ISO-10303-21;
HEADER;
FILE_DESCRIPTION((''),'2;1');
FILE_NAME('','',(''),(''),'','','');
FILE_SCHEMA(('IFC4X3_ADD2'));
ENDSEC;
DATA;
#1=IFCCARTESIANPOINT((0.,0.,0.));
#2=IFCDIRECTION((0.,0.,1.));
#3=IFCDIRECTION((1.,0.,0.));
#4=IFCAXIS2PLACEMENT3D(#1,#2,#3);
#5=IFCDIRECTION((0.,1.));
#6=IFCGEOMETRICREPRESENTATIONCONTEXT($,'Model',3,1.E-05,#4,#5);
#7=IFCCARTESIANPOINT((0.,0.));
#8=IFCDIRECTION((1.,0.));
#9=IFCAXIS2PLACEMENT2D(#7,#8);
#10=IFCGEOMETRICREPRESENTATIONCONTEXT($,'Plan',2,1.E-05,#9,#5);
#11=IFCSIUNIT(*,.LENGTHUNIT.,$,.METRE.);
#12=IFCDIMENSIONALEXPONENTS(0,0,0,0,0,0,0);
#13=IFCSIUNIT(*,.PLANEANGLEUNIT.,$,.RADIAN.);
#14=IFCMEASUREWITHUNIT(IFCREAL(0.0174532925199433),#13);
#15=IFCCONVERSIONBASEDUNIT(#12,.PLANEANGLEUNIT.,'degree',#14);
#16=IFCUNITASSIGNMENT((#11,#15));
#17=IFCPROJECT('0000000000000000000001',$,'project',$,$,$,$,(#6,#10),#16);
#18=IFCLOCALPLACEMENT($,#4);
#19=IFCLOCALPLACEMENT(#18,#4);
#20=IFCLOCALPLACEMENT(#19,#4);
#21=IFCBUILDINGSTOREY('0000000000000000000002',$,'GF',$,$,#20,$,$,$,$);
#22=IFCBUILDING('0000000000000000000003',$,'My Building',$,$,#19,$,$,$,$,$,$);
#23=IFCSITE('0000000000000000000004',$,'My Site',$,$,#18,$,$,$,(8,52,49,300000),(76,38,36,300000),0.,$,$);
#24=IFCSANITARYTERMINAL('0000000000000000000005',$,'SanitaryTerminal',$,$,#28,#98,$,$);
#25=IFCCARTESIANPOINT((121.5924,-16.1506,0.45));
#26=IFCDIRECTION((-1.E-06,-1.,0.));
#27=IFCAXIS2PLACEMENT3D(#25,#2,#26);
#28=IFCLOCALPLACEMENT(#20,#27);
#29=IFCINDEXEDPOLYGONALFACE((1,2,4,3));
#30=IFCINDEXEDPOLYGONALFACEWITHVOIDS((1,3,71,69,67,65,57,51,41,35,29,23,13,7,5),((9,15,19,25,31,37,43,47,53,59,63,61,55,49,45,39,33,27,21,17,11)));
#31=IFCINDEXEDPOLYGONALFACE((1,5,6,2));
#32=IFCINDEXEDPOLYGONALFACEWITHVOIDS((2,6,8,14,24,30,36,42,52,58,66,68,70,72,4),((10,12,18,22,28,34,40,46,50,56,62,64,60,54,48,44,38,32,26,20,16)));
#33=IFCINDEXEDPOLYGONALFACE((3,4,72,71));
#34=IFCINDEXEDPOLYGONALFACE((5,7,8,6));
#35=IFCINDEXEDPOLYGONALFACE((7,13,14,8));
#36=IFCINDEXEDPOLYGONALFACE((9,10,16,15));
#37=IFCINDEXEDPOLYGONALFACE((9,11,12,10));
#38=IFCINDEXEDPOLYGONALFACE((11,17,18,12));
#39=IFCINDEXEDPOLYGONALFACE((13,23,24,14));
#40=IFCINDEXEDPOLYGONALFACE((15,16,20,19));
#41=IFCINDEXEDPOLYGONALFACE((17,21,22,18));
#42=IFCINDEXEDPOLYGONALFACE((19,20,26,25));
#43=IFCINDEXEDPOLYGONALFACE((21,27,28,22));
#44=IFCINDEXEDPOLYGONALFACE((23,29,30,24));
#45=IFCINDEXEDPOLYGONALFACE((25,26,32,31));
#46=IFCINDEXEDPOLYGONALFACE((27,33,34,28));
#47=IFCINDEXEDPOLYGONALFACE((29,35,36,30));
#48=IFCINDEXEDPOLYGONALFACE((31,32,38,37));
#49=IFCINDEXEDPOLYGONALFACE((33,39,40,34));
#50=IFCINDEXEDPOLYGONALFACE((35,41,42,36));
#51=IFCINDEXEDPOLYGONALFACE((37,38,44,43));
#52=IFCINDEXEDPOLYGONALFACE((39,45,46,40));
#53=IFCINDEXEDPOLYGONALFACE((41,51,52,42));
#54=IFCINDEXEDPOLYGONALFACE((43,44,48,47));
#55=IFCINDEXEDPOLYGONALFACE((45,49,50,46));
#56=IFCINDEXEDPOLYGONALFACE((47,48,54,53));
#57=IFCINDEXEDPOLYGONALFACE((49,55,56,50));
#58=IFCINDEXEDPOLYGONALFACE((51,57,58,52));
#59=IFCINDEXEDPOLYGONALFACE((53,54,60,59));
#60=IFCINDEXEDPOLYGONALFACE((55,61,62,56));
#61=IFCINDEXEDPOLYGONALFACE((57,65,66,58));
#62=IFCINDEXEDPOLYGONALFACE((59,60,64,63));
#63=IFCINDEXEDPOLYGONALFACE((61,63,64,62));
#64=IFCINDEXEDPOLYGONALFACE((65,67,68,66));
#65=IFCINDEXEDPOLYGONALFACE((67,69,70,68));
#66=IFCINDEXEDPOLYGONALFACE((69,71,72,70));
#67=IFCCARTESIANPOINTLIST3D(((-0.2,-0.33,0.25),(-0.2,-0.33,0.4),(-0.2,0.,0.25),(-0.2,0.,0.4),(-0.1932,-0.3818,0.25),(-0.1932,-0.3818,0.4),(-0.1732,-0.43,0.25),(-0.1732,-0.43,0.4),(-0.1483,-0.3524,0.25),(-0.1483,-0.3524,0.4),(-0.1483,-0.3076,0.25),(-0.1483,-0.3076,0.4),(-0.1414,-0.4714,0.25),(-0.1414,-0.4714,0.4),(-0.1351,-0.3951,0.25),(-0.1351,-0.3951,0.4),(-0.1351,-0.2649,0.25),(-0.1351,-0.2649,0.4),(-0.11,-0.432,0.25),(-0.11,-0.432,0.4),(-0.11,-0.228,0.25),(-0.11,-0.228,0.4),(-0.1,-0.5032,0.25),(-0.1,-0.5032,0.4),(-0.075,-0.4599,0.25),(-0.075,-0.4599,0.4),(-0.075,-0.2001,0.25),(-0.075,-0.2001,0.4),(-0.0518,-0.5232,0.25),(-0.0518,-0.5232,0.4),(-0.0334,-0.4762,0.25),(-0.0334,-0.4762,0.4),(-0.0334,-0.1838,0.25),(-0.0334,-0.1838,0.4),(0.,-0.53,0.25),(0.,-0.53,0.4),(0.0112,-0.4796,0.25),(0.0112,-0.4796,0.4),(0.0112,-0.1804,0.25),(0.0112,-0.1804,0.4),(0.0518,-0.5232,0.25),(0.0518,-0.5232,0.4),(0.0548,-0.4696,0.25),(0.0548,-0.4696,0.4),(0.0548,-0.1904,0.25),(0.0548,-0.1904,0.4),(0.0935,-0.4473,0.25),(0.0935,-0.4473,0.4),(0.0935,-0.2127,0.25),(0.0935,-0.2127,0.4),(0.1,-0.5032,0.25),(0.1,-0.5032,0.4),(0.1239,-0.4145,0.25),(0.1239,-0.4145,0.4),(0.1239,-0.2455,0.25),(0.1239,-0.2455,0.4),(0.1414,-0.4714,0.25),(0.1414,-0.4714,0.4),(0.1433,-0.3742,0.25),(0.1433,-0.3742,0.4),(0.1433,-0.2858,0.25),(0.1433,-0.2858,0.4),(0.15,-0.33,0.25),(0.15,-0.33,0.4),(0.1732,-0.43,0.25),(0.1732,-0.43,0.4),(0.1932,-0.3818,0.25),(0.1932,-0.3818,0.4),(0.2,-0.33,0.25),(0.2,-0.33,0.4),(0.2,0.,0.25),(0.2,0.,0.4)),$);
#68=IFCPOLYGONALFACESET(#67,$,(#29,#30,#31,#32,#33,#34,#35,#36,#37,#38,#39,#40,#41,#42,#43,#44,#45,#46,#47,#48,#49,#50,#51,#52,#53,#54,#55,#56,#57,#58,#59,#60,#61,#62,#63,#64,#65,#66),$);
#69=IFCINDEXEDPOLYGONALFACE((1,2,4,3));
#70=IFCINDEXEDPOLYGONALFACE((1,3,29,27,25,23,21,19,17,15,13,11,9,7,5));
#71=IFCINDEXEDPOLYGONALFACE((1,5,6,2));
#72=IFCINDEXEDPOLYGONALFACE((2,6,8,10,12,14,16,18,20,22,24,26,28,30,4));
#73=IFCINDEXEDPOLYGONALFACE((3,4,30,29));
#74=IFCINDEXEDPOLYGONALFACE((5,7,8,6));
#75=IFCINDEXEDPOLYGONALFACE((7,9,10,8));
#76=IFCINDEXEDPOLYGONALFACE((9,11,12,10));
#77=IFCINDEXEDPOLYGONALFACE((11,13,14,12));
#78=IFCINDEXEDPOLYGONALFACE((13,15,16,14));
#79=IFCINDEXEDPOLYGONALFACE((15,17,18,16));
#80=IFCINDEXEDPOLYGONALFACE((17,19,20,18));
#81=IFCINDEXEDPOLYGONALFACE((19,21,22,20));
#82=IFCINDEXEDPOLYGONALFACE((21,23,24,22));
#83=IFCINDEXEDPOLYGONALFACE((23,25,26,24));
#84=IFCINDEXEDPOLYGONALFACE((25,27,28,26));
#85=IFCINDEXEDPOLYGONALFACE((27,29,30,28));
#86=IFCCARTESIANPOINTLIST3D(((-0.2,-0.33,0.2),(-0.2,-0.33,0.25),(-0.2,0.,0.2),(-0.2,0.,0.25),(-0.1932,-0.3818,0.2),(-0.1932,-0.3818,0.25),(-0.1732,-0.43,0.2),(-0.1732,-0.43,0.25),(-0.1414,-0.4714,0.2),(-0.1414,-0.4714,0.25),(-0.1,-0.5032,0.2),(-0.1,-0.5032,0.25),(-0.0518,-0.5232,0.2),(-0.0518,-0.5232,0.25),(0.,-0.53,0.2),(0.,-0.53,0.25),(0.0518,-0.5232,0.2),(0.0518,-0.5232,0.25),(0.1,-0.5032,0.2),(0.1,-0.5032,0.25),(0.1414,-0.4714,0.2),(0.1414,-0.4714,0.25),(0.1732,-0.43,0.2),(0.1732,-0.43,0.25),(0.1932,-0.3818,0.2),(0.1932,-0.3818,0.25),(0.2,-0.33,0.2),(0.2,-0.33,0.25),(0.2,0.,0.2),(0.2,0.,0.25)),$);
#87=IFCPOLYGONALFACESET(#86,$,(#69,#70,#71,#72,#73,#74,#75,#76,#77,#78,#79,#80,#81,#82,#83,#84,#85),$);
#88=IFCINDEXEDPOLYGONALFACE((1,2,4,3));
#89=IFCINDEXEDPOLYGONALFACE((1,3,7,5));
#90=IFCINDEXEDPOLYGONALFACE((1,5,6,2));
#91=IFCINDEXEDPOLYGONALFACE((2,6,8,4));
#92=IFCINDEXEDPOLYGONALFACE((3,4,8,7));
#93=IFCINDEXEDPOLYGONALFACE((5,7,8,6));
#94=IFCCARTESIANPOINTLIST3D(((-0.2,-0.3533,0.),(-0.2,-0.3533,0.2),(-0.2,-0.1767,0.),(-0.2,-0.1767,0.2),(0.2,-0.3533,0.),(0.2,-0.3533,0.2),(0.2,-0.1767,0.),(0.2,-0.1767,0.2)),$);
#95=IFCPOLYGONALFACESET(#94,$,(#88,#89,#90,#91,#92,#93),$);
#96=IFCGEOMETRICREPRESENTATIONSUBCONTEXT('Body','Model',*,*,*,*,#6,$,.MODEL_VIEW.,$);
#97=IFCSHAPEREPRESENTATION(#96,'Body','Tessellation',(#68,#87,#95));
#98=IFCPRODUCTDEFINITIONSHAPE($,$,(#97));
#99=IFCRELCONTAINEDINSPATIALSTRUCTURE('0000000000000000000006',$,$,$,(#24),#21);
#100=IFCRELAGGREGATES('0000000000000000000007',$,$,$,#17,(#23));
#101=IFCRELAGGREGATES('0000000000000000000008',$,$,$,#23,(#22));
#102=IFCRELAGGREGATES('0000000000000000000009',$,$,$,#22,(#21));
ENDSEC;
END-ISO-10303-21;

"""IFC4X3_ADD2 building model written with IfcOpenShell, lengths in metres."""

from ifc_helpers import new_model, entity, si_unit, converted_unit, direction, frame, frame_2d, origin_with_axes, origin_2d_with_axis, place, context, subcontext, project, spatial, line, arc, indexed_curve, circle_curve, outline, extrude, shape, element, save


model = new_model("IFC4X3_ADD2")

# Units and contexts
model_context = context("Model", 3, precision=1e-05, world=origin_with_axes(), true_north=direction((0.0, 1.0)))
plan_context = context("Plan", 2, precision=1e-05, world=origin_2d_with_axis(), true_north=direction((0.0, 1.0)))
body_context_1 = subcontext(model_context, "Body", "Model", "MODEL_VIEW")
body_context_2 = subcontext(plan_context, "Body", "Plan", "PLAN_VIEW")
ifc_project = project(units=[si_unit("LENGTHUNIT", "METRE"), converted_unit("PLANEANGLEUNIT", "degree", entity("IfcReal", 0.0174532925199433), si_unit("PLANEANGLEUNIT", "RADIAN"), dimensions=[0, 0, 0, 0, 0, 0, 0])], contexts=[model_context, plan_context])

# Site, building, storey
site_placement = place(None, origin_with_axes())
site = spatial("IfcSite", under=ifc_project, at=site_placement, Name="My Site", RefLatitude=(8, 52, 49, 300000), RefLongitude=(76, 38, 36, 300000), RefElevation=0.0)
building_placement = place(site_placement, origin_with_axes())
building = spatial("IfcBuilding", under=site, at=building_placement, Name="My Building")
storey_placement = place(building_placement, origin_with_axes())
storey = spatial("IfcBuildingStorey", under=building, at=storey_placement, Name="GF")

# Sanitary terminal
sanitary_terminal_1_placement = place(storey_placement, frame((121.5924, -16.1506, 0.45), z_axis=(0.0, 0.0, 1.0), x_axis=(-0.000001, -1.0, 0.0)))
element("IfcSanitaryTerminal", 1, at=sanitary_terminal_1_placement, inside=storey, Name="SanitaryTerminal", shapes=[
    shape(body_context_1, "Body", "SweptSolid", [extrude(outline(indexed_curve([(-0.2, 0.0), (0.2, 0.0), (0.2, -0.33), (0.1414, -0.4714), (0.0, -0.53), (-0.1414, -0.4714), (-0.2, -0.33)], segments=[line(1, 2), line(2, 3), arc(3, 4, 5), arc(5, 6, 7), line(7, 1)]), holes=[circle_curve(frame_2d((0.0, -0.33)), 0.15)]), frame((0.0, 0.0, 0.25), z_axis=(0.0, 0.0, 1.0), x_axis=(1.0, 0.0, 0.0)), (0.0, 0.0, 1.0), 0.15), extrude(outline(indexed_curve([(-0.2, 0.0), (0.2, 0.0), (0.2, -0.33), (0.1414, -0.4714), (0.0, -0.53), (-0.1414, -0.4714), (-0.2, -0.33)], segments=[line(1, 2), line(2, 3), arc(3, 4, 5), arc(5, 6, 7), line(7, 1)])), frame((0.0, 0.0, 0.2), z_axis=(0.0, 0.0, 1.0), x_axis=(1.0, 0.0, 0.0)), (0.0, 0.0, 1.0), 0.05), extrude(outline(indexed_curve([(-0.2, -0.1767), (0.2, -0.1767), (0.2, -0.3533), (-0.2, -0.3533)], segments=[line(1, 2, 3, 4, 1)])), origin_with_axes(), (0.0, 0.0, 1.0), 0.2)]),
    shape(body_context_2, "Body", "Annotation2D", [entity("IfcAnnotationFillArea", entity("IfcIndexedPolyCurve", entity("IfcCartesianPointList2D", [[-0.2, -0.159], [-0.1872, 0.0], [0.1872, 0.0], [0.2, -0.159], [0.1962, -0.2314], [0.1848, -0.301], [0.1764, -0.3339], [0.1663, -0.3651], [0.1546, -0.3944], [0.1414, -0.4213], [0.1269, -0.4458], [0.1111, -0.4675], [0.0943, -0.4862], [0.0765, -0.5018], [0.0581, -0.514], [0.039, -0.5229], [0.0196, -0.5282], [0.0, -0.53], [-0.0196, -0.5282], [-0.039, -0.5229], [-0.0581, -0.514], [-0.0765, -0.5018], [-0.0943, -0.4862], [-0.1111, -0.4675], [-0.1269, -0.4458], [-0.1414, -0.4213], [-0.1546, -0.3944], [-0.1663, -0.3651], [-0.1764, -0.3339], [-0.1848, -0.301], [-0.1962, -0.2314], [-0.1109, -0.1393], [-0.1068, -0.124], [-0.0957, -0.1129], [-0.0804, -0.1088], [0.0804, -0.1088], [-0.1025, -0.3926], [-0.1109, -0.3476], [-0.0424, -0.4563], [-0.0784, -0.4308], [0.0, -0.4652], [0.1068, -0.124], [0.1109, -0.1393], [0.0957, -0.1129], [0.0784, -0.4308], [0.0905, -0.4117], [0.0424, -0.4563], [0.1025, -0.3926], [0.1109, -0.3476]]), [entity("IfcLineIndex", [19, 18]), entity("IfcLineIndex", [18, 17]), entity("IfcLineIndex", [17, 16]), entity("IfcLineIndex", [16, 15]), entity("IfcLineIndex", [15, 14]), entity("IfcLineIndex", [14, 13]), entity("IfcLineIndex", [13, 12]), entity("IfcLineIndex", [12, 11]), entity("IfcLineIndex", [11, 46]), entity("IfcLineIndex", [46, 45]), entity("IfcLineIndex", [45, 47]), entity("IfcLineIndex", [47, 41]), entity("IfcLineIndex", [41, 39]), entity("IfcLineIndex", [39, 40]), entity("IfcLineIndex", [40, 37]), entity("IfcLineIndex", [37, 27]), entity("IfcLineIndex", [27, 26]), entity("IfcLineIndex", [26, 25]), entity("IfcLineIndex", [25, 24]), entity("IfcLineIndex", [24, 23]), entity("IfcLineIndex", [23, 22]), entity("IfcLineIndex", [22, 21]), entity("IfcLineIndex", [21, 20]), entity("IfcLineIndex", [20, 19])])), entity("IfcAnnotationFillArea", entity("IfcIndexedPolyCurve", entity("IfcCartesianPointList2D", [[-0.2, -0.159], [-0.1872, 0.0], [0.1872, 0.0], [0.2, -0.159], [0.1962, -0.2314], [0.1848, -0.301], [0.1764, -0.3339], [0.1663, -0.3651], [0.1546, -0.3944], [0.1414, -0.4213], [0.1269, -0.4458], [0.1111, -0.4675], [0.0943, -0.4862], [0.0765, -0.5018], [0.0581, -0.514], [0.039, -0.5229], [0.0196, -0.5282], [0.0, -0.53], [-0.0196, -0.5282], [-0.039, -0.5229], [-0.0581, -0.514], [-0.0765, -0.5018], [-0.0943, -0.4862], [-0.1111, -0.4675], [-0.1269, -0.4458], [-0.1414, -0.4213], [-0.1546, -0.3944], [-0.1663, -0.3651], [-0.1764, -0.3339], [-0.1848, -0.301], [-0.1962, -0.2314], [-0.1109, -0.1393], [-0.1068, -0.124], [-0.0957, -0.1129], [-0.0804, -0.1088], [0.0804, -0.1088], [-0.1025, -0.3926], [-0.1109, -0.3476], [-0.0424, -0.4563], [-0.0784, -0.4308], [0.0, -0.4652], [0.1068, -0.124], [0.1109, -0.1393], [0.0957, -0.1129], [0.0784, -0.4308], [0.0905, -0.4117], [0.0424, -0.4563], [0.1025, -0.3926], [0.1109, -0.3476]]), [entity("IfcLineIndex", [11, 10]), entity("IfcLineIndex", [10, 9]), entity("IfcLineIndex", [9, 8]), entity("IfcLineIndex", [8, 7]), entity("IfcLineIndex", [7, 6]), entity("IfcLineIndex", [6, 5]), entity("IfcLineIndex", [5, 4]), entity("IfcLineIndex", [4, 3]), entity("IfcLineIndex", [3, 2]), entity("IfcLineIndex", [2, 1]), entity("IfcLineIndex", [1, 31]), entity("IfcLineIndex", [31, 30]), entity("IfcLineIndex", [30, 29]), entity("IfcLineIndex", [29, 28]), entity("IfcLineIndex", [28, 27]), entity("IfcLineIndex", [27, 37]), entity("IfcLineIndex", [37, 38]), entity("IfcLineIndex", [38, 32]), entity("IfcLineIndex", [32, 33]), entity("IfcLineIndex", [33, 34]), entity("IfcLineIndex", [34, 35]), entity("IfcLineIndex", [35, 36]), entity("IfcLineIndex", [36, 44]), entity("IfcLineIndex", [44, 42]), entity("IfcLineIndex", [42, 43]), entity("IfcLineIndex", [43, 49]), entity("IfcLineIndex", [49, 48]), entity("IfcLineIndex", [48, 46]), entity("IfcLineIndex", [46, 11])])), entity("IfcAnnotationFillArea", entity("IfcIndexedPolyCurve", entity("IfcCartesianPointList2D", [[-0.2, -0.159], [-0.1872, 0.0], [0.1872, 0.0], [0.2, -0.159], [0.1962, -0.2314], [0.1848, -0.301], [0.1764, -0.3339], [0.1663, -0.3651], [0.1546, -0.3944], [0.1414, -0.4213], [0.1269, -0.4458], [0.1111, -0.4675], [0.0943, -0.4862], [0.0765, -0.5018], [0.0581, -0.514], [0.039, -0.5229], [0.0196, -0.5282], [0.0, -0.53], [-0.0196, -0.5282], [-0.039, -0.5229], [-0.0581, -0.514], [-0.0765, -0.5018], [-0.0943, -0.4862], [-0.1111, -0.4675], [-0.1269, -0.4458], [-0.1414, -0.4213], [-0.1546, -0.3944], [-0.1663, -0.3651], [-0.1764, -0.3339], [-0.1848, -0.301], [-0.1962, -0.2314], [-0.1109, -0.1393], [-0.1068, -0.124], [-0.0957, -0.1129], [-0.0804, -0.1088], [0.0804, -0.1088], [-0.1025, -0.3926], [-0.1109, -0.3476], [-0.0424, -0.4563], [-0.0784, -0.4308], [0.0, -0.4652], [0.1068, -0.124], [0.1109, -0.1393], [0.0957, -0.1129], [0.0784, -0.4308], [0.0905, -0.4117], [0.0424, -0.4563], [0.1025, -0.3926], [0.1109, -0.3476]]), [entity("IfcLineIndex", [45, 46]), entity("IfcLineIndex", [46, 48]), entity("IfcLineIndex", [48, 49]), entity("IfcLineIndex", [49, 43]), entity("IfcLineIndex", [43, 42]), entity("IfcLineIndex", [42, 44]), entity("IfcLineIndex", [44, 36]), entity("IfcLineIndex", [36, 35]), entity("IfcLineIndex", [35, 34]), entity("IfcLineIndex", [34, 33]), entity("IfcLineIndex", [33, 32]), entity("IfcLineIndex", [32, 38]), entity("IfcLineIndex", [38, 37]), entity("IfcLineIndex", [37, 40]), entity("IfcLineIndex", [40, 39]), entity("IfcLineIndex", [39, 41]), entity("IfcLineIndex", [41, 47]), entity("IfcLineIndex", [47, 45])]))]),
])

save(model, "model.ifc")
